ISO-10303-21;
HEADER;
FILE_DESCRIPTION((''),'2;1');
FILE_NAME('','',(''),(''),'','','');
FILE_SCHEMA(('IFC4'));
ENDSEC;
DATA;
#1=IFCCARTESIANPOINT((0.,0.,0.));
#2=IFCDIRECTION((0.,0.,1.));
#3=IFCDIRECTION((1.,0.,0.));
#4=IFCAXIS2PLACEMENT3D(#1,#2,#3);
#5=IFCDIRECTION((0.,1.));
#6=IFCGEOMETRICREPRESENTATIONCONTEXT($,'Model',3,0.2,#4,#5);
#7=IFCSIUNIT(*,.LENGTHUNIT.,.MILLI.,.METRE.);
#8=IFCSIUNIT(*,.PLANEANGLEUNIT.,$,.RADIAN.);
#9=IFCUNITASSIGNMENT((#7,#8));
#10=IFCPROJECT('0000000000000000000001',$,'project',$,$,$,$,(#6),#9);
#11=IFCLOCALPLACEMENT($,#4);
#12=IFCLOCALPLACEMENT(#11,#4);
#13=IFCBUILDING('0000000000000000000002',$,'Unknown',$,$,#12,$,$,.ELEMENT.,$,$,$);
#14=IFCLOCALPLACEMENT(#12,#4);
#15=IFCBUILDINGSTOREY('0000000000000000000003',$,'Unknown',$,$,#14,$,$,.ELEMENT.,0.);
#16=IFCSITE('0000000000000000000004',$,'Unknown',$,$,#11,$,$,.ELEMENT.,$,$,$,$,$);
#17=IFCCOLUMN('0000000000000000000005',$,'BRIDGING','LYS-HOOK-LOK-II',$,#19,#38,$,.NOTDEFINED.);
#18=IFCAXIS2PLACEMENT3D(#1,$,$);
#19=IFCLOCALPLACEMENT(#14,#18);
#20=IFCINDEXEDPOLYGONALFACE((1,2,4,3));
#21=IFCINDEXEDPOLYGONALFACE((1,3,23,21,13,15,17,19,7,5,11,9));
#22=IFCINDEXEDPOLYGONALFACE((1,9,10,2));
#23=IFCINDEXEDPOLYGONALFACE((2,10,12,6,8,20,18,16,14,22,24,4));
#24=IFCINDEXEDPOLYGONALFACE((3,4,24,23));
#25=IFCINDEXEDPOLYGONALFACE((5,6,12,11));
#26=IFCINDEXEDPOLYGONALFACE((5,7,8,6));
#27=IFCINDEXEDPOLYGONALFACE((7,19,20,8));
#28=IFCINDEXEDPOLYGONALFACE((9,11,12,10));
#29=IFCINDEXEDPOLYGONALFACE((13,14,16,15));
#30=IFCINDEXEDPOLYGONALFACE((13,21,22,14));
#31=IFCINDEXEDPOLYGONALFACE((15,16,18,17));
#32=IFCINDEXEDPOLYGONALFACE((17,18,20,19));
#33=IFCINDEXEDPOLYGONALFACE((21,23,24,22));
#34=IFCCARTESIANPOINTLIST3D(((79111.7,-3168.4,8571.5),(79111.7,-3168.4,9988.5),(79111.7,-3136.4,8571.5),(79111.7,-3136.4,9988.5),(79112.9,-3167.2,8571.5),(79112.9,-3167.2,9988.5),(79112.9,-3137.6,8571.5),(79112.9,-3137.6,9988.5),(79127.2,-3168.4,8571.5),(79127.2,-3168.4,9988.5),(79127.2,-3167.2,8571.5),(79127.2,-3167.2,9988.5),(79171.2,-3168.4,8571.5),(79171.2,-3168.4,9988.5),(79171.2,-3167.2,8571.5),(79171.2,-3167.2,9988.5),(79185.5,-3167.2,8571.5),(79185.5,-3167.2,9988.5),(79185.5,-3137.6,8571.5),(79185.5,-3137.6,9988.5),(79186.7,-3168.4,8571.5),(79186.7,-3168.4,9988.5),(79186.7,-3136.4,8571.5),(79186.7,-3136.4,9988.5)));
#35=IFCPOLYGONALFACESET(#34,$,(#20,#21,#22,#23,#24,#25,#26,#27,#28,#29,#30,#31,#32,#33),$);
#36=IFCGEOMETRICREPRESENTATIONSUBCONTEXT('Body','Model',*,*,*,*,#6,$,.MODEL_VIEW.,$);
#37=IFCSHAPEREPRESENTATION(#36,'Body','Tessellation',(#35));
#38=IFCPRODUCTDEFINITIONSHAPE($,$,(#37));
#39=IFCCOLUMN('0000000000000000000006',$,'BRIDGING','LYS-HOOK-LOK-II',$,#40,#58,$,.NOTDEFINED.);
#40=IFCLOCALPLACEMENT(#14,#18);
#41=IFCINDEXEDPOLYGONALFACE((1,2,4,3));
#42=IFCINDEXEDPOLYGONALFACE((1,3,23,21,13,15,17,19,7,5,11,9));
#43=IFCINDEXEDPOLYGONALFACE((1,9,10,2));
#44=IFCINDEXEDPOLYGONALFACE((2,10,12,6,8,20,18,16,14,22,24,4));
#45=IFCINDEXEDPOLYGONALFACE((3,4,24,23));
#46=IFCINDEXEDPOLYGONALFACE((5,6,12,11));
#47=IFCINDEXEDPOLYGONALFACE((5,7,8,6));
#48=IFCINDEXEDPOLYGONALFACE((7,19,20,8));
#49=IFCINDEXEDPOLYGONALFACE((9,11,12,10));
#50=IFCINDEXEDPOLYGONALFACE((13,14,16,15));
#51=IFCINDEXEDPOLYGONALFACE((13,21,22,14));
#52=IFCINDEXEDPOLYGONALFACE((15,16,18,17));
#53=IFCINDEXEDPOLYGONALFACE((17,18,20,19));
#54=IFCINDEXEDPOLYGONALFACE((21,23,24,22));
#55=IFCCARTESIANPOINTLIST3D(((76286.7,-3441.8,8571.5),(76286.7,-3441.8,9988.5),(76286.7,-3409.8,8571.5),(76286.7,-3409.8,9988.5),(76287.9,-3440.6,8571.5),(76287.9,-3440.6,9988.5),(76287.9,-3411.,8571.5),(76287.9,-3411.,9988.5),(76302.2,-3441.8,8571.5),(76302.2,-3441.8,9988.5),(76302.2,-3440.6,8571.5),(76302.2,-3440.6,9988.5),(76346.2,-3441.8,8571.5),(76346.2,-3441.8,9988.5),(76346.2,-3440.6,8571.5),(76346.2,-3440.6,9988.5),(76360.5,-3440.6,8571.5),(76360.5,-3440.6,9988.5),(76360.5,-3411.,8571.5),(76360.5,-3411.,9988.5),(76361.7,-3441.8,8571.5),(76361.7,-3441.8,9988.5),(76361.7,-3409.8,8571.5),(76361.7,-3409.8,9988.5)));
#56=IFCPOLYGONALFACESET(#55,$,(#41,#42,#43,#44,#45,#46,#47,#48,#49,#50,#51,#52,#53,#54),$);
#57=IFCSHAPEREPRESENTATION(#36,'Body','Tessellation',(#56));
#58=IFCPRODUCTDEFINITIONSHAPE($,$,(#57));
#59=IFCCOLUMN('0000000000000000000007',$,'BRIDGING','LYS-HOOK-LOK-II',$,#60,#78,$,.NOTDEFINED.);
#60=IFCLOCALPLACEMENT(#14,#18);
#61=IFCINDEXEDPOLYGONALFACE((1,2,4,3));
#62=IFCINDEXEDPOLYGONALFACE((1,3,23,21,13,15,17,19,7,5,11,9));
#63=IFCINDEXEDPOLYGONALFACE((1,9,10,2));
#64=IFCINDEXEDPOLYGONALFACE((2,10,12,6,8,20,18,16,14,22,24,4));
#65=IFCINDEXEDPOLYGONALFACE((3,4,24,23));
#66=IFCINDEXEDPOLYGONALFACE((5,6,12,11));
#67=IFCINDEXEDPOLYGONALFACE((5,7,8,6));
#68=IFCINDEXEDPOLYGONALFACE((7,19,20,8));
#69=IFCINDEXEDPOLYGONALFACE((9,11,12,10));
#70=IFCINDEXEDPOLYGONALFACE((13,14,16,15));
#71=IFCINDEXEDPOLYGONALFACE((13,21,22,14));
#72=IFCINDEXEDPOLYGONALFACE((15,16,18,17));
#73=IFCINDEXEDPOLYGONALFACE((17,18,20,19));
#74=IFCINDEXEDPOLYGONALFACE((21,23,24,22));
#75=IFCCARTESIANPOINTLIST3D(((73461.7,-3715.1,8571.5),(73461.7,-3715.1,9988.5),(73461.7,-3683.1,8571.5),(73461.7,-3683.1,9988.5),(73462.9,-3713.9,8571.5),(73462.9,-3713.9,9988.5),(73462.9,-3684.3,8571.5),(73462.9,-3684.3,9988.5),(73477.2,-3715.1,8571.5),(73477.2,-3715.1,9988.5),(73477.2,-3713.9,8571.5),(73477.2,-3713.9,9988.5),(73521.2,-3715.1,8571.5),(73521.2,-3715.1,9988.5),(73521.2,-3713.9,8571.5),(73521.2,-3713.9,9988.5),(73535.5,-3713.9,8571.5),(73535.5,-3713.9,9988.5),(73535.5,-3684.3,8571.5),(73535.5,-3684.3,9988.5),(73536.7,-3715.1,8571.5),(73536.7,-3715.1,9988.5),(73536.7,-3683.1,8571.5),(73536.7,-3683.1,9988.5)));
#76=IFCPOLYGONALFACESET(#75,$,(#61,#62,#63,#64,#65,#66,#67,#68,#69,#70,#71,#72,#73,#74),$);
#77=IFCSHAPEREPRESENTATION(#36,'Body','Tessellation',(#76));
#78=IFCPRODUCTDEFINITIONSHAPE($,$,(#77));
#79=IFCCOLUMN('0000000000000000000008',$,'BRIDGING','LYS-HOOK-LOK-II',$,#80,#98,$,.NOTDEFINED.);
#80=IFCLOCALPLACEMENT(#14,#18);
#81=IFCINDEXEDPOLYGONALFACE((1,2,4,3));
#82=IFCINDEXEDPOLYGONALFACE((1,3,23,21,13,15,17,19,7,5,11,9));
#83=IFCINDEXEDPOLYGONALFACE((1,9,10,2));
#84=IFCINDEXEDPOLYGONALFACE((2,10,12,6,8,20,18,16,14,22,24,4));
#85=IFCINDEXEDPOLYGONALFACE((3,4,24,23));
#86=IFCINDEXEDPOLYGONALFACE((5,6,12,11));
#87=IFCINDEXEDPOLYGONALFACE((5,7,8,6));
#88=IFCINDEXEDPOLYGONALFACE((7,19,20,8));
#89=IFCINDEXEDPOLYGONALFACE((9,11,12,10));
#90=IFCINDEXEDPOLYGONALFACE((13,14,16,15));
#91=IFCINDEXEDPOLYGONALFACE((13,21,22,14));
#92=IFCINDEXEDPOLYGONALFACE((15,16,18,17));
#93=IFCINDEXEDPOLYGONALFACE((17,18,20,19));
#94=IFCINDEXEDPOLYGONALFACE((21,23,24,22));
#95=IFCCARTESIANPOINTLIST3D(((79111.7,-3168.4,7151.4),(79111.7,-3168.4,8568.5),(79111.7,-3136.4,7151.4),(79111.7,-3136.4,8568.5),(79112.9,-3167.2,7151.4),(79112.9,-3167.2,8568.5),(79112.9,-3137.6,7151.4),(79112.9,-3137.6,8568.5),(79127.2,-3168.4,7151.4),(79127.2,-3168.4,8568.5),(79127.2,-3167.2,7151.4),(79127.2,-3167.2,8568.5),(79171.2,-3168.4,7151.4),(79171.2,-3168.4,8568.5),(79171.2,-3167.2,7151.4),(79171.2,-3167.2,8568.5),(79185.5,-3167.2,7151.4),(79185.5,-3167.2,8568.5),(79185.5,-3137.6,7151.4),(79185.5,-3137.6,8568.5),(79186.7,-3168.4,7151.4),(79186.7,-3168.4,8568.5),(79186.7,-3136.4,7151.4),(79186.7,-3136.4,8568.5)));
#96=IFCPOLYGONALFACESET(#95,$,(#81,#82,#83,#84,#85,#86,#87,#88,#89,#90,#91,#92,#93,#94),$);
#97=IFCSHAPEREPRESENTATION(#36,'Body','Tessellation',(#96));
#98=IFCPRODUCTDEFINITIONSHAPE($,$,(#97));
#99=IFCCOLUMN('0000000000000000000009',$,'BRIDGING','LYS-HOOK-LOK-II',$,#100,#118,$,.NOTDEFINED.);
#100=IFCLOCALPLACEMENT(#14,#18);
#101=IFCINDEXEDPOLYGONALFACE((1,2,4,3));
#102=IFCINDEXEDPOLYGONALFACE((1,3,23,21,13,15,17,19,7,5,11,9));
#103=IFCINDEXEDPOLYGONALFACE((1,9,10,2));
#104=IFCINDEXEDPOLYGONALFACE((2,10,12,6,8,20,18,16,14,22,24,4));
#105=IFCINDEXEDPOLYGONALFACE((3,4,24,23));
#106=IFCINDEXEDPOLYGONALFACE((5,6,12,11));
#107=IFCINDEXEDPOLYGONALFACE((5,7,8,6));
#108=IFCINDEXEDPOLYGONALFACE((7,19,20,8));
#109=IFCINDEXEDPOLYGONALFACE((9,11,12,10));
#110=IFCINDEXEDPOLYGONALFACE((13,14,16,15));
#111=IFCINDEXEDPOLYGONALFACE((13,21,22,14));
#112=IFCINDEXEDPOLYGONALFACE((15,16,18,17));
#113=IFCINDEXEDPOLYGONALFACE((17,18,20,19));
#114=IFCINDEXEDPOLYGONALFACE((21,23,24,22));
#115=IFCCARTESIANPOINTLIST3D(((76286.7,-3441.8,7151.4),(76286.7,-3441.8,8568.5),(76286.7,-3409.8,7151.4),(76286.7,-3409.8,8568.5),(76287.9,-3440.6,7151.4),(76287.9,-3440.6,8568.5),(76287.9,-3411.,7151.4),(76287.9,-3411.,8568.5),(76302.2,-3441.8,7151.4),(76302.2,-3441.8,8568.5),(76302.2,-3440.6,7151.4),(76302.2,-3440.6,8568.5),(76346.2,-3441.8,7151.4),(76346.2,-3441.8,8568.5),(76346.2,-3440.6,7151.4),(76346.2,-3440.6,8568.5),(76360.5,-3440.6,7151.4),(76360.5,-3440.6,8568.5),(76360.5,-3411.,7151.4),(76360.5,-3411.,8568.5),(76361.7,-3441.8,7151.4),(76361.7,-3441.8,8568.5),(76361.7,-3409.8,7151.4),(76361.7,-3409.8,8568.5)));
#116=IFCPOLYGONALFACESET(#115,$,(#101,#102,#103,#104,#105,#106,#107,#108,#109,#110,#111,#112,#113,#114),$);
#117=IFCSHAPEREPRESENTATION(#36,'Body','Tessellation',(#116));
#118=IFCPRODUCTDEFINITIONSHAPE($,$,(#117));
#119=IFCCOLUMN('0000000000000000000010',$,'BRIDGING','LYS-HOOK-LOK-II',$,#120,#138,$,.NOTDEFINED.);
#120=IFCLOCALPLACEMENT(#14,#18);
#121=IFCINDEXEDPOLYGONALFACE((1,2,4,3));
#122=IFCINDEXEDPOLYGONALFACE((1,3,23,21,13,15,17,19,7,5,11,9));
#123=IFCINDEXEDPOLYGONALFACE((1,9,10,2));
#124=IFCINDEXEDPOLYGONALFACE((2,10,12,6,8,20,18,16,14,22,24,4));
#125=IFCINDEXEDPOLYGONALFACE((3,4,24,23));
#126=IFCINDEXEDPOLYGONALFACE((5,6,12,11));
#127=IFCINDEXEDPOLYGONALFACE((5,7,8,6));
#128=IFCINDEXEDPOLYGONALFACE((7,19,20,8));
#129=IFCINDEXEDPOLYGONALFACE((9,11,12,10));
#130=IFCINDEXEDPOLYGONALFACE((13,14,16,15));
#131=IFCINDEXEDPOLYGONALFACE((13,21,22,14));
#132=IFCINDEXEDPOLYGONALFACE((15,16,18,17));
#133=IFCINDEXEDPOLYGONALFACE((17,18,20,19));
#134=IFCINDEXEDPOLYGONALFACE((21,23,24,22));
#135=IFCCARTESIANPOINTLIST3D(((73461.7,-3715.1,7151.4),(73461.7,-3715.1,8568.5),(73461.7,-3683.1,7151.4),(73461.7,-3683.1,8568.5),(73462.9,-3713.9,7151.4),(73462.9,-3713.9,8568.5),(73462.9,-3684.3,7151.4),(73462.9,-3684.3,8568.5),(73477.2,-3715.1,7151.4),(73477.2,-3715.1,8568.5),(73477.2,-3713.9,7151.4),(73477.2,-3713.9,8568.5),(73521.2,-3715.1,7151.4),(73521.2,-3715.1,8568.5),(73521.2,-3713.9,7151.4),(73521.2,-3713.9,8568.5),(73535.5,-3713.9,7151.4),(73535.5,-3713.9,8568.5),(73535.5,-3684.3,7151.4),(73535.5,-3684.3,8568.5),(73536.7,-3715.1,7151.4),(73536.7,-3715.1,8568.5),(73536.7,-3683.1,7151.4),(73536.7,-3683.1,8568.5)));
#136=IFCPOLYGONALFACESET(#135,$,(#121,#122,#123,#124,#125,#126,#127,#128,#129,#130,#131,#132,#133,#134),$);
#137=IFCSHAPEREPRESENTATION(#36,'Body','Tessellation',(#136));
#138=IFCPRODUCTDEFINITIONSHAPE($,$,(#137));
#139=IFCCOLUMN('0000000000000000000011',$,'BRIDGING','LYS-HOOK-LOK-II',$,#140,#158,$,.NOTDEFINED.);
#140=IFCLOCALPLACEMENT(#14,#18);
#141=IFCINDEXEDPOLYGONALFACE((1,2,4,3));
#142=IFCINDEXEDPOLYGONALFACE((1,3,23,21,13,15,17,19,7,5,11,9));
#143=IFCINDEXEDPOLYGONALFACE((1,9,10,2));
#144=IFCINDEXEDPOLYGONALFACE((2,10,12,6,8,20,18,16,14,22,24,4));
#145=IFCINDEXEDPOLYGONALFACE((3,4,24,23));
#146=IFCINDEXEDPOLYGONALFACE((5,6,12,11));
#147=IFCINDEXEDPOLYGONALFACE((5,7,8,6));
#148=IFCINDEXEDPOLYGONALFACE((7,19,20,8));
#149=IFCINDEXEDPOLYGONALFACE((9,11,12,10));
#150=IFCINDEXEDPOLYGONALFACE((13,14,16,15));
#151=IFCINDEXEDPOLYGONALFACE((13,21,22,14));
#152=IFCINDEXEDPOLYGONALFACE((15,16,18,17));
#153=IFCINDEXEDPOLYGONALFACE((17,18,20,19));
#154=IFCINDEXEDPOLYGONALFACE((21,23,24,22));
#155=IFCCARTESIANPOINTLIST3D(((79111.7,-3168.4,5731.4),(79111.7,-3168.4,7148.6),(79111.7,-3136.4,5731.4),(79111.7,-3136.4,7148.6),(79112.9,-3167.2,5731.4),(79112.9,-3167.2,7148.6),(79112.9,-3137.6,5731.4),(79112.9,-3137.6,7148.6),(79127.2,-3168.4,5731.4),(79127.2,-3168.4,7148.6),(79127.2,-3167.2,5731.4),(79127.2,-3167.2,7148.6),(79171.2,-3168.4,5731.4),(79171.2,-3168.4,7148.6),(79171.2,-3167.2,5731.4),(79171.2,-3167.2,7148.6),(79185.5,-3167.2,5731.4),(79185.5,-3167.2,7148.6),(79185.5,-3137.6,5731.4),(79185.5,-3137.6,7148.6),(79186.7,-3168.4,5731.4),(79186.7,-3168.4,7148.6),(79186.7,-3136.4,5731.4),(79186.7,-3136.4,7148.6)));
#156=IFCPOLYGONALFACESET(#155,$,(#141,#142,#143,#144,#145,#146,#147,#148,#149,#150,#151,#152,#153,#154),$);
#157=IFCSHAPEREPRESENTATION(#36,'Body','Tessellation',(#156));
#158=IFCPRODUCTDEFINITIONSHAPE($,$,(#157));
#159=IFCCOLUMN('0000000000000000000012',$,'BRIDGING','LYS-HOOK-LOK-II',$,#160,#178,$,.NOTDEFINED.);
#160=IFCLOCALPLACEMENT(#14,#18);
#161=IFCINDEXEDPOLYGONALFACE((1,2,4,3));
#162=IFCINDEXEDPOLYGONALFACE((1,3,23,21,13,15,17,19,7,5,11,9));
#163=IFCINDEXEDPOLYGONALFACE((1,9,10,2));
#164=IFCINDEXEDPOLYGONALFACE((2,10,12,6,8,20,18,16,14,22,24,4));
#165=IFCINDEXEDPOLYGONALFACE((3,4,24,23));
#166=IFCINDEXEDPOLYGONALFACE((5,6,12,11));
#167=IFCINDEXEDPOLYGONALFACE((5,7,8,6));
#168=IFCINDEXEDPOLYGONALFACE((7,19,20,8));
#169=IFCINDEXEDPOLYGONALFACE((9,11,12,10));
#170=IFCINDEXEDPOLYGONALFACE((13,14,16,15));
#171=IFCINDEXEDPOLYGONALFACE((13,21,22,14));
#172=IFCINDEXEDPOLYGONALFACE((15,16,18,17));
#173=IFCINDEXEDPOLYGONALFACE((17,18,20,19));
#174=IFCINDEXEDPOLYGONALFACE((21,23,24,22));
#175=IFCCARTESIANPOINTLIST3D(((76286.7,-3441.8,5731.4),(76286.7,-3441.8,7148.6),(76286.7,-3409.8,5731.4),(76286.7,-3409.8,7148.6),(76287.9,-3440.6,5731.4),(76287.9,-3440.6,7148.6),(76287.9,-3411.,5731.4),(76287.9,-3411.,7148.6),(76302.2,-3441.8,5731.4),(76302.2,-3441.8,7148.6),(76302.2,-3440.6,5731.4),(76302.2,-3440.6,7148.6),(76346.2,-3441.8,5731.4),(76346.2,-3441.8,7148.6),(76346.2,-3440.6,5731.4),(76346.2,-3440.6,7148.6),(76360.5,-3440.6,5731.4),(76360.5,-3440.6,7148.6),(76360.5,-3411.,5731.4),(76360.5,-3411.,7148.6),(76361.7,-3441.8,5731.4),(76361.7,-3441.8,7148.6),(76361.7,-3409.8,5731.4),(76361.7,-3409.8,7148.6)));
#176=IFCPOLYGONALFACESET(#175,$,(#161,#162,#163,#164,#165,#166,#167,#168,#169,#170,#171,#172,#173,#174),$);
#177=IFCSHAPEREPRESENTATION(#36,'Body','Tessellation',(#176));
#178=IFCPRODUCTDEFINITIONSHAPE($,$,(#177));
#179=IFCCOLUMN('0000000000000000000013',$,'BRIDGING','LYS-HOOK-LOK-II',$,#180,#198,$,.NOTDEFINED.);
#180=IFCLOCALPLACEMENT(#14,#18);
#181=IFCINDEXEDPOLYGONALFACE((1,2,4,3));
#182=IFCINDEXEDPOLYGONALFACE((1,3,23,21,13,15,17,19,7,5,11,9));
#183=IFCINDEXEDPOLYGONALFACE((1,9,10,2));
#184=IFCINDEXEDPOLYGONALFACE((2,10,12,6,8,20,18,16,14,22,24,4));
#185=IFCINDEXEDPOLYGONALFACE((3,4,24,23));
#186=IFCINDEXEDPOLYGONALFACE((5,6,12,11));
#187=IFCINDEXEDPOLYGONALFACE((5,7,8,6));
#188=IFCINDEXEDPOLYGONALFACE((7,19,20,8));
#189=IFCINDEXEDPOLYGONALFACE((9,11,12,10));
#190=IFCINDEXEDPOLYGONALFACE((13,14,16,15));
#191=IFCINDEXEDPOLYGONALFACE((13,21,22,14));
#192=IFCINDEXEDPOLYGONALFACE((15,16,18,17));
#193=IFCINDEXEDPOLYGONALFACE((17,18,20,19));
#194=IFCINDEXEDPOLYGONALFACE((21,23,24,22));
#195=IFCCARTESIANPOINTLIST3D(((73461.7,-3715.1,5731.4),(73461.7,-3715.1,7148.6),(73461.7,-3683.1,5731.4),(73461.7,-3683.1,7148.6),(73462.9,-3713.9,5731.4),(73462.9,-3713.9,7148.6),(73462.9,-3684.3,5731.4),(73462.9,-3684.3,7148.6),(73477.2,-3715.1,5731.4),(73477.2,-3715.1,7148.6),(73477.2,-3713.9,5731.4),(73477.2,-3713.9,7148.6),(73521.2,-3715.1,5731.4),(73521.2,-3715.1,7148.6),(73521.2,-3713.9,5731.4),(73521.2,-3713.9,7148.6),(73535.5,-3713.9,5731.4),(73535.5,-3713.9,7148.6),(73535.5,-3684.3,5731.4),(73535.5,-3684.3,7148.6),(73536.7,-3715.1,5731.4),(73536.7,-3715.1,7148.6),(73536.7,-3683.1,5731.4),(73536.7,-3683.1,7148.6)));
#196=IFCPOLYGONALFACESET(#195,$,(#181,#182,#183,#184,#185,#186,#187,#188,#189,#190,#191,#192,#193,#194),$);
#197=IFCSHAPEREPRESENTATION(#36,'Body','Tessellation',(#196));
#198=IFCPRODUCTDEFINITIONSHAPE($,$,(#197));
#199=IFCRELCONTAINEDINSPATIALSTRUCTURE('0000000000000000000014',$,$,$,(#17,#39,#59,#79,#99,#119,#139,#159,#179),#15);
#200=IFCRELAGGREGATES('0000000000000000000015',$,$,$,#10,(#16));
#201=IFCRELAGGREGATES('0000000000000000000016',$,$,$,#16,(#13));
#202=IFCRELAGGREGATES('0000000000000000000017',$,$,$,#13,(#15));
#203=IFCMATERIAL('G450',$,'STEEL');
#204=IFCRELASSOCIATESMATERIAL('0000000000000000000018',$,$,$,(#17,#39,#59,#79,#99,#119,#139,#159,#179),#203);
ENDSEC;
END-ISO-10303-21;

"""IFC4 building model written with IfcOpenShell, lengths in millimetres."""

from ifc_helpers import new_model, si_unit, direction, frame, origin_with_axes, place, context, subcontext, project, spatial, line, indexed_curve, outline, extrude, material, element, save


model = new_model("IFC4")

# Units and contexts
model_context = context("Model", 3, precision=0.2, world=origin_with_axes(), true_north=direction((0.0, 1.0)))
body_context = subcontext(model_context, "Body", "Model", "MODEL_VIEW")
ifc_project = project(units=[si_unit("LENGTHUNIT", "METRE", prefix="MILLI"), si_unit("PLANEANGLEUNIT", "RADIAN")], contexts=[model_context])

# Site, building, storey
site_placement = place(None, origin_with_axes())
site = spatial("IfcSite", under=ifc_project, at=site_placement, Name="Unknown", CompositionType="ELEMENT")
building_placement = place(site_placement, origin_with_axes())
building = spatial("IfcBuilding", under=site, at=building_placement, Name="Unknown", CompositionType="ELEMENT")
storey_placement = place(building_placement, origin_with_axes())
storey = spatial("IfcBuildingStorey", under=building, at=storey_placement, Name="Unknown", CompositionType="ELEMENT", Elevation=0.0)

# Columns
ifc_material_1 = material(Name="G450", Category="STEEL")
for number, where, z_axis, x_axis, name in (
    (1, (79149.2, -3152.4, 8571.5), (0.0, -1.0, 0.0), (0.0, 0.0, 1.0), "BRIDGING"),
    (2, (76324.2, -3425.8, 8571.5), (0.0, -1.0, 0.0), (0.0, 0.0, 1.0), "BRIDGING"),
    (3, (73499.2, -3699.1, 8571.5), (0.0, -1.0, 0.0), (0.0, 0.0, 1.0), "BRIDGING"),
):
    element("IfcColumn", number, at=place(storey_placement, frame(where, z_axis=z_axis, x_axis=x_axis)), inside=storey, material=ifc_material_1, Name=name, Description="LYS-HOOK-LOK-II", PredefinedType="NOTDEFINED", context=body_context, shape_type="SolidModel", body=[
        extrude(outline(indexed_curve([(16.0, -37.5), (16.0, -22.0), (14.8, -22.0), (14.8, -36.3), (-14.8, -36.3), (-14.8, 36.3), (14.8, 36.3), (14.8, 22.0), (16.0, 22.0), (16.0, 37.5), (-16.0, 37.5), (-16.0, -37.5)], segments=[line(1, 2, 3, 4, 5, 6, 7, 8, 9, 10, 11, 12, 1)])), frame((0.0, 0.0, 0.0), z_axis=(-1.0, 0.0, 0.0), x_axis=(0.0, 0.0, 1.0)), (0.0, 0.0, -1.0), 1417.0),
    ])
for number, where, z_axis, x_axis, name in (
    (4, (79149.2, -3152.4, 7151.4), (0.0, -1.0, 0.0), (0.0, 0.0, 1.0), "BRIDGING"),
    (5, (76324.2, -3425.8, 7151.4), (0.0, -1.0, 0.0), (0.0, 0.0, 1.0), "BRIDGING"),
    (6, (73499.2, -3699.1, 7151.4), (0.0, -1.0, 0.0), (0.0, 0.0, 1.0), "BRIDGING"),
):
    element("IfcColumn", number, at=place(storey_placement, frame(where, z_axis=z_axis, x_axis=x_axis)), inside=storey, material=ifc_material_1, Name=name, Description="LYS-HOOK-LOK-II", PredefinedType="NOTDEFINED", context=body_context, shape_type="SolidModel", body=[
        extrude(outline(indexed_curve([(16.0, -37.5), (16.0, -22.0), (14.8, -22.0), (14.8, -36.3), (-14.8, -36.3), (-14.8, 36.3), (14.8, 36.3), (14.8, 22.0), (16.0, 22.0), (16.0, 37.5), (-16.0, 37.5), (-16.0, -37.5)], segments=[line(1, 2, 3, 4, 5, 6, 7, 8, 9, 10, 11, 12, 1)])), frame((0.0, 0.0, 0.0), z_axis=(-1.0, 0.0, 0.0), x_axis=(0.0, 0.0, 1.0)), (0.0, 0.0, -1.0), 1417.1),
    ])
for number, where, z_axis, x_axis, name in (
    (7, (79149.2, -3152.4, 5731.4), (0.0, -1.0, 0.0), (0.0, 0.0, 1.0), "BRIDGING"),
    (8, (76324.2, -3425.8, 5731.4), (0.0, -1.0, 0.0), (0.0, 0.0, 1.0), "BRIDGING"),
    (9, (73499.2, -3699.1, 5731.4), (0.0, -1.0, 0.0), (0.0, 0.0, 1.0), "BRIDGING"),
):
    element("IfcColumn", number, at=place(storey_placement, frame(where, z_axis=z_axis, x_axis=x_axis)), inside=storey, material=ifc_material_1, Name=name, Description="LYS-HOOK-LOK-II", PredefinedType="NOTDEFINED", context=body_context, shape_type="SolidModel", body=[
        extrude(outline(indexed_curve([(16.0, -37.5), (16.0, -22.0), (14.8, -22.0), (14.8, -36.3), (-14.8, -36.3), (-14.8, 36.3), (14.8, 36.3), (14.8, 22.0), (16.0, 22.0), (16.0, 37.5), (-16.0, 37.5), (-16.0, -37.5)], segments=[line(1, 2, 3, 4, 5, 6, 7, 8, 9, 10, 11, 12, 1)])), frame((0.0, 0.0, 0.0), z_axis=(-1.0, 0.0, 0.0), x_axis=(0.0, 0.0, 1.0)), (0.0, 0.0, -1.0), 1417.2),
    ])

save(model, "model.ifc")
